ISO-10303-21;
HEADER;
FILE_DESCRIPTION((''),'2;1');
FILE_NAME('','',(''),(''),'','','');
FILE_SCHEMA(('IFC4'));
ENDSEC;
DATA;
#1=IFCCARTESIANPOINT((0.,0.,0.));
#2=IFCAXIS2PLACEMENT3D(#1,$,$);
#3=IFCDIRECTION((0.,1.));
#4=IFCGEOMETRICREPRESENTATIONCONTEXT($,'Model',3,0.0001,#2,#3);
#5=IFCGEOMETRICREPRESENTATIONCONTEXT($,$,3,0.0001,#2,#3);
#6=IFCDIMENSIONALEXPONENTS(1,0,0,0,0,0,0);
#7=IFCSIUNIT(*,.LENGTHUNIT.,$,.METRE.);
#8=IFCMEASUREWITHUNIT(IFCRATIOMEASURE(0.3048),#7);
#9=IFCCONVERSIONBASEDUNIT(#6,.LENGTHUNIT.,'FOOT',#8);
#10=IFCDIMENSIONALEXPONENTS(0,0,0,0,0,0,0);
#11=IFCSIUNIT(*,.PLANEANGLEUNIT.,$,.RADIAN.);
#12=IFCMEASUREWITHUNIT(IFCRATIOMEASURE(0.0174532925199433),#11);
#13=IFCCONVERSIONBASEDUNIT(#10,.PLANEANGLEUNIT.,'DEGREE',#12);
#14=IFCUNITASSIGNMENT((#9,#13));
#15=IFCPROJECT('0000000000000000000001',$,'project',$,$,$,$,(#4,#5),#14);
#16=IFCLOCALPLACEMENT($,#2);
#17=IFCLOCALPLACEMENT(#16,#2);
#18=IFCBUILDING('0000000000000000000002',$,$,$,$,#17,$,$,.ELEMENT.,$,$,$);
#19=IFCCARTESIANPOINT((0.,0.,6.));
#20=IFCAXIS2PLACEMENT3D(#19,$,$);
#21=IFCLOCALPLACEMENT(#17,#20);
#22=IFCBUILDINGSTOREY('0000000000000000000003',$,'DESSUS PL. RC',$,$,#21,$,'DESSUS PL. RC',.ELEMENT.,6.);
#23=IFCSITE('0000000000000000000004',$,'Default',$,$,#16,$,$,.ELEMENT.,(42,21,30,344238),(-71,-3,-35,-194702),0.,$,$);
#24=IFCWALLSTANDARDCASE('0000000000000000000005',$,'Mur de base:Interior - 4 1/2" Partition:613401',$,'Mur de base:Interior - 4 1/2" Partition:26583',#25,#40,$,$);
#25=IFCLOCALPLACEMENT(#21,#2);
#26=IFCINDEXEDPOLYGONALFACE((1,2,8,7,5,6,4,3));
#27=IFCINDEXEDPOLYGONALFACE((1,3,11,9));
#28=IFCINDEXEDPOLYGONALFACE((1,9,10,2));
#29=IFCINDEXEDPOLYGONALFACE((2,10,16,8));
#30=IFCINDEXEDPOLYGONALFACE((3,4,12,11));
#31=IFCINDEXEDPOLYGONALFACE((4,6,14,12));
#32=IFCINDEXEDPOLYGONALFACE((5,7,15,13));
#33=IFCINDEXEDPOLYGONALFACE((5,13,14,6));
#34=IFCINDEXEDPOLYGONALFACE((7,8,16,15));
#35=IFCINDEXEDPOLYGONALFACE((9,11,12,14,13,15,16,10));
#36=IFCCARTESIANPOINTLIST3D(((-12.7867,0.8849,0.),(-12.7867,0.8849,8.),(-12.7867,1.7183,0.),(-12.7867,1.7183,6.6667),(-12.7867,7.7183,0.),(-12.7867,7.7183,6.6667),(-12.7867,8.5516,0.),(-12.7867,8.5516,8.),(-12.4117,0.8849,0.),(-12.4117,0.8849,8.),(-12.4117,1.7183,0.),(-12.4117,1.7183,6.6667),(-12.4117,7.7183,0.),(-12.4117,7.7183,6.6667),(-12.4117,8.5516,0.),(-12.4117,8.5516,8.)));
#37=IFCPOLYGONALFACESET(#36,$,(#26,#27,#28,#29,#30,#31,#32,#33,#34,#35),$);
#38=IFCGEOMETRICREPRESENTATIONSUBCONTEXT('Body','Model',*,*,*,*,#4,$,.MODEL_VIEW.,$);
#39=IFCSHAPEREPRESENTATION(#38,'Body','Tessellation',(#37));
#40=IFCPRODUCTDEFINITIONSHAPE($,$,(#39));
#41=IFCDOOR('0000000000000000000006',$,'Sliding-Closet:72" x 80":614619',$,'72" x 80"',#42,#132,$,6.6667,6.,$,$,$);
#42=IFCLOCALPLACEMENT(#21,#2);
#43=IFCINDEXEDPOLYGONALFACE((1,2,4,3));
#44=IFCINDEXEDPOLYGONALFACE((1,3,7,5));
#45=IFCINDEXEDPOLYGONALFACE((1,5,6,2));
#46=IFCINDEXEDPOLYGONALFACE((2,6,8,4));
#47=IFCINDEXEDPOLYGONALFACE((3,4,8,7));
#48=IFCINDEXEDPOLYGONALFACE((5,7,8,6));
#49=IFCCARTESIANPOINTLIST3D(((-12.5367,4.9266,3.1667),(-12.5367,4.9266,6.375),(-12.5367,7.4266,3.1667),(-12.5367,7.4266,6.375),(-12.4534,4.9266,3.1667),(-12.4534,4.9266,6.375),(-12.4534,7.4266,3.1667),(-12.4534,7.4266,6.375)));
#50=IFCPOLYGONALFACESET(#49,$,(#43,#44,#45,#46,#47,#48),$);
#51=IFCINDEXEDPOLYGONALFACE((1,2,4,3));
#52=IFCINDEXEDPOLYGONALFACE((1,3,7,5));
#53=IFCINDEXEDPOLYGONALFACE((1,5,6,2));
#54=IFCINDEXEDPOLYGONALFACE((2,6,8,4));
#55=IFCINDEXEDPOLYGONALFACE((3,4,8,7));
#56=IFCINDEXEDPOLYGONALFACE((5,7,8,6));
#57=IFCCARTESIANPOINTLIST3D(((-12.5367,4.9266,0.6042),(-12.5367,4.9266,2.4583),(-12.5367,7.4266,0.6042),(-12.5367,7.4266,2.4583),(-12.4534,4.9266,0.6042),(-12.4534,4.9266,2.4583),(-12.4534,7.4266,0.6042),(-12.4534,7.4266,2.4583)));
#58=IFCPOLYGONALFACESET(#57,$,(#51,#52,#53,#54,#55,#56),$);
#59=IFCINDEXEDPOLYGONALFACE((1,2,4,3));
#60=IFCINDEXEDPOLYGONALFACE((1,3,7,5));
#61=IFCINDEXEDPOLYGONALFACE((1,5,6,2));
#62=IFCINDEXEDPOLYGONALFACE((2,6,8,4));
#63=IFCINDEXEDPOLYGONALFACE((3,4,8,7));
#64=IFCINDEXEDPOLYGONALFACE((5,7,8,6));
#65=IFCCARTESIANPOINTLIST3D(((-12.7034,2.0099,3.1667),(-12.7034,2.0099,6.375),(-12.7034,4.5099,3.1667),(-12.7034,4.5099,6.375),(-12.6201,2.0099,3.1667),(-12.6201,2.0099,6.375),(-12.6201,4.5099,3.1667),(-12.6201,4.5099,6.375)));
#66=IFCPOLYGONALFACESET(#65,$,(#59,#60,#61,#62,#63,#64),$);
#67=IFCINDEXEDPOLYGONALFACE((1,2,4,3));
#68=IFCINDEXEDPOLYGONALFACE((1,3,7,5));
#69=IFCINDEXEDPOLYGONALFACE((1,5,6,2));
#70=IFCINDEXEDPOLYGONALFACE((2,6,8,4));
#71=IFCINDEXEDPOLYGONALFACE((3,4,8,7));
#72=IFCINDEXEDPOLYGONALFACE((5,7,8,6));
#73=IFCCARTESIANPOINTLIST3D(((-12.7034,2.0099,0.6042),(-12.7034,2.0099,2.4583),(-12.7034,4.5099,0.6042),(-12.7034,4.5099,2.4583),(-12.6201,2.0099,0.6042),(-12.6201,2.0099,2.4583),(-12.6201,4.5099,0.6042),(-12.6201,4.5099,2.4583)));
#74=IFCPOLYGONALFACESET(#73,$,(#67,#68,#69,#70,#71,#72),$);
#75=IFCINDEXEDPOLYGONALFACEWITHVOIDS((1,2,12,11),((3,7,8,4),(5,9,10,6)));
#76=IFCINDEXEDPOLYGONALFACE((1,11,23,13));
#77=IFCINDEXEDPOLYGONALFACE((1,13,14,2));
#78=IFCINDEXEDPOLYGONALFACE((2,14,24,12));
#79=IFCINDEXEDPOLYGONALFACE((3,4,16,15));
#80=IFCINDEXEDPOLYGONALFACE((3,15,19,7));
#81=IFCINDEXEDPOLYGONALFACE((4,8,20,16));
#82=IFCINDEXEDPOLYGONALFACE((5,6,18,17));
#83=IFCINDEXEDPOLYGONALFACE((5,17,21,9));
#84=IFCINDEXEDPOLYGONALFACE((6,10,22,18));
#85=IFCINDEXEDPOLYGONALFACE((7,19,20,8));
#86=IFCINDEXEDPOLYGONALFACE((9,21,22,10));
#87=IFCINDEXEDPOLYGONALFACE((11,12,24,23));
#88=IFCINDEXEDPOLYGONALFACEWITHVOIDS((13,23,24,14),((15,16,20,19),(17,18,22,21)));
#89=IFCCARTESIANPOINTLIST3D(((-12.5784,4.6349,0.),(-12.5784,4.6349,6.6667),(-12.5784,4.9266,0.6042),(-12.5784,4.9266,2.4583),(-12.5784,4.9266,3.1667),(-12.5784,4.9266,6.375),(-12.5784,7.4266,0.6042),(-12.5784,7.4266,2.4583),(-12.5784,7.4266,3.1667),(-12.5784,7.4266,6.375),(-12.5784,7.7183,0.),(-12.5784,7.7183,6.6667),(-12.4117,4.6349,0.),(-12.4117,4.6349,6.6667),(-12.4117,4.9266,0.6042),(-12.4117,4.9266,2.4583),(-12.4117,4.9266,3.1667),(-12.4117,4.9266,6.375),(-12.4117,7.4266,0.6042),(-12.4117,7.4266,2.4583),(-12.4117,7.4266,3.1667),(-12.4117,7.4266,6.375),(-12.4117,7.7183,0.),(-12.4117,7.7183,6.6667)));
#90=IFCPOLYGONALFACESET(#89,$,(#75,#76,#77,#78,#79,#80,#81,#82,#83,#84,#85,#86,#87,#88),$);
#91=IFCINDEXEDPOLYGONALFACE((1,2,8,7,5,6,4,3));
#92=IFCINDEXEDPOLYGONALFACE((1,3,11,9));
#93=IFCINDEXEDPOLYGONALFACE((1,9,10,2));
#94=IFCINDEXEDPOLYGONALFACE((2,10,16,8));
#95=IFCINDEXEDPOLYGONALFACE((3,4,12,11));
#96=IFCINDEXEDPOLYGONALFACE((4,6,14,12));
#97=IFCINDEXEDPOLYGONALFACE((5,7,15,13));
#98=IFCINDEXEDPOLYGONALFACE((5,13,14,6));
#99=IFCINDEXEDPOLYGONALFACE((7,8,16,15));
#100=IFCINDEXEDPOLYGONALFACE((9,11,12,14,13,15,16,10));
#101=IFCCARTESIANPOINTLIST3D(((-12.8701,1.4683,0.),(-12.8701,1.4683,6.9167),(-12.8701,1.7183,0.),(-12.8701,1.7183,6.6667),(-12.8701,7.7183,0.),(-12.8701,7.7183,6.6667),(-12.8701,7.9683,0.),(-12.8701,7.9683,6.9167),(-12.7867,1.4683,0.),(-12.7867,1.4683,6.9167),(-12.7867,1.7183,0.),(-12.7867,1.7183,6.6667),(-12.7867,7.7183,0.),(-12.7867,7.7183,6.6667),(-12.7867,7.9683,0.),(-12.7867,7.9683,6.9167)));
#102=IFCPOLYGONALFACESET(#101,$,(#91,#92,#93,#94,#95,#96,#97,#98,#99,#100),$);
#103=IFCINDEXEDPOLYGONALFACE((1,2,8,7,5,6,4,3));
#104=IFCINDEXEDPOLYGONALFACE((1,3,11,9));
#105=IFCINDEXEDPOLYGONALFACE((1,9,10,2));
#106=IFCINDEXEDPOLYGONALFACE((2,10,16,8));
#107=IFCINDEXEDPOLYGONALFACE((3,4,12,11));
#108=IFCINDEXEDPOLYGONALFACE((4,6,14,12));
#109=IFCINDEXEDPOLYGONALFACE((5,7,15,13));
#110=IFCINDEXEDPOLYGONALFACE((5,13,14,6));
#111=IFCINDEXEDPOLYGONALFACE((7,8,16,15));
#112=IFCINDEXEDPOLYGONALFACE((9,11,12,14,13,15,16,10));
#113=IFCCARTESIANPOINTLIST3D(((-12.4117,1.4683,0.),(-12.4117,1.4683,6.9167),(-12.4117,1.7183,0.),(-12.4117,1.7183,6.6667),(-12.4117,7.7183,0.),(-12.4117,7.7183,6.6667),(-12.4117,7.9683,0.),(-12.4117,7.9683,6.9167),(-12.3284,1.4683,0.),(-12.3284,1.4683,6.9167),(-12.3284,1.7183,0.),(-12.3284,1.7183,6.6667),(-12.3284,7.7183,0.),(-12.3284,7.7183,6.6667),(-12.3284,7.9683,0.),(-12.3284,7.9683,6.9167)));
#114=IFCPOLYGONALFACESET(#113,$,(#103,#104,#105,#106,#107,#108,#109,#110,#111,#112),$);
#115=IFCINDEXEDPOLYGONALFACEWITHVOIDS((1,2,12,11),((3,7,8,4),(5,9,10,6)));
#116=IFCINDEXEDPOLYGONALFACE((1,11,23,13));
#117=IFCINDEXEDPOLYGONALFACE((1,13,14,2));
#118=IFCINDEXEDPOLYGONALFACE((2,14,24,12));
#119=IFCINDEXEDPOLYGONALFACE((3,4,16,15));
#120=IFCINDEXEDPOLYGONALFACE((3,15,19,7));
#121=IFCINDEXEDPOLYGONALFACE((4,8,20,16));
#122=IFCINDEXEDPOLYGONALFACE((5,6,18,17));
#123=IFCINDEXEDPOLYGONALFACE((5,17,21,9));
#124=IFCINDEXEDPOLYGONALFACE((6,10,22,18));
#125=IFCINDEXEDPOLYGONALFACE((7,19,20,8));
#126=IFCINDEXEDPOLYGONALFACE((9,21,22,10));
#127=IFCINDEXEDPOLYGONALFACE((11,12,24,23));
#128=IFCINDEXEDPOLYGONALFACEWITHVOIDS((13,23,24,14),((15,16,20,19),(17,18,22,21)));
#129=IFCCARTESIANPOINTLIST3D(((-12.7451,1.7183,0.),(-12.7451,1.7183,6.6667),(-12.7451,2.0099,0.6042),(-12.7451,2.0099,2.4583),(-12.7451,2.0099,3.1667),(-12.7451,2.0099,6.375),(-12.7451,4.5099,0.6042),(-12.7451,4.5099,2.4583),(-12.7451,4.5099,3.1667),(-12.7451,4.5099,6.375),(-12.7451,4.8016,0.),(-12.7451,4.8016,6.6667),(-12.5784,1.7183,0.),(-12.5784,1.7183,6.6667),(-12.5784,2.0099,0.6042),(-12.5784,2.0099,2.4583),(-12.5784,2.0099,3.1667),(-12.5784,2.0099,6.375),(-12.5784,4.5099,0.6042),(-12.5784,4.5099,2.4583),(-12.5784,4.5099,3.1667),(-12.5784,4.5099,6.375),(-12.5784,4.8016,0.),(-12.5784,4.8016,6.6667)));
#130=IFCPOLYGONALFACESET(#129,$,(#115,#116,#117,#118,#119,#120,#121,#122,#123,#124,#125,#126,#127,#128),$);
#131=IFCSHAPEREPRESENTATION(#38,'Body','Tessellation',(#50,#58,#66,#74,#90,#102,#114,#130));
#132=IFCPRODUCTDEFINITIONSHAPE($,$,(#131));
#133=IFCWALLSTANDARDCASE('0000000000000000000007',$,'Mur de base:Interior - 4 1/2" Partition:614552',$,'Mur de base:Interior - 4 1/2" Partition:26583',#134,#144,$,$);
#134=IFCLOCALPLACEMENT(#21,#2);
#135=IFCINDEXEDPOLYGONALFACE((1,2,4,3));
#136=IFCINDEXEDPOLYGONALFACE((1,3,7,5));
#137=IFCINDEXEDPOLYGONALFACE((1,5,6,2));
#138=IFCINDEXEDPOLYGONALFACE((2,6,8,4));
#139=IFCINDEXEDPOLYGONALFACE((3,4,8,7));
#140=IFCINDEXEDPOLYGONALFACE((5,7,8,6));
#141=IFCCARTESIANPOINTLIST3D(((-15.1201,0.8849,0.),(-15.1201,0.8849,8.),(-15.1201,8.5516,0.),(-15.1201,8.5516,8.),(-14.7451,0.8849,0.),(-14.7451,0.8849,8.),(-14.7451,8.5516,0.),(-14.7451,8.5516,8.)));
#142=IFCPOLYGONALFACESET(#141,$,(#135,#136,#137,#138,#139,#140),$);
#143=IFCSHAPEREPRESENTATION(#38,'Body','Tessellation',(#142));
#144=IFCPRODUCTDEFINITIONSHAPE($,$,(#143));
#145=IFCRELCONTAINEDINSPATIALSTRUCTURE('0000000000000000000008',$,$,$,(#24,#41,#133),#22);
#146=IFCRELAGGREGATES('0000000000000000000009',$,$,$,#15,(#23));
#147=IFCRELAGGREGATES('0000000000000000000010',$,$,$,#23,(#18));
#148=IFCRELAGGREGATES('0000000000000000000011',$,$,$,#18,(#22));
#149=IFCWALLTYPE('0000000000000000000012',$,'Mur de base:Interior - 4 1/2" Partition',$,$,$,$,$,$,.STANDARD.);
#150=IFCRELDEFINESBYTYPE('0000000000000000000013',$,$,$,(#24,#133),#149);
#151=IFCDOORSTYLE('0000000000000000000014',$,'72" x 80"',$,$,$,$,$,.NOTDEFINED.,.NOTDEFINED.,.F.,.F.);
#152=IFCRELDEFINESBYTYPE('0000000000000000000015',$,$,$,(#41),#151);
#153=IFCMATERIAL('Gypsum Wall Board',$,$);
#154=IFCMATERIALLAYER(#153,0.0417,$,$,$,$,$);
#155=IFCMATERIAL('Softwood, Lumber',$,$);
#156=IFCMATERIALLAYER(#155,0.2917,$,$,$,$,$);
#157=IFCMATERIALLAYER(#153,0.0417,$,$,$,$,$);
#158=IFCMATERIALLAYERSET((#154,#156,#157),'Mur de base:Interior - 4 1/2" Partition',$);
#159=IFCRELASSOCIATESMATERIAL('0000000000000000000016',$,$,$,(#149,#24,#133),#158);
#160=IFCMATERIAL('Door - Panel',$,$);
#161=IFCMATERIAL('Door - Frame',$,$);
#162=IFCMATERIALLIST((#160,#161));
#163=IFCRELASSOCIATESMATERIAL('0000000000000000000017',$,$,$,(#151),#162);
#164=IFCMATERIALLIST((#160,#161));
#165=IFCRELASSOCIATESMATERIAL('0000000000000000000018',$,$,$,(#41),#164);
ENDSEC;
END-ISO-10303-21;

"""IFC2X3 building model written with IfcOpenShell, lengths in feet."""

from ifc_helpers import new_model, entity, si_unit, converted_unit, direction, frame, frame_2d, origin, origin_2d_with_axis, place, context, subcontext, project, spatial, polyline, rectangle, outline, extrude, source, transform, mapped, material, material_list, layer, layer_set, layer_usage, type_object, type_shapes, element, fill, save


model = new_model("IFC2X3")

# Units and contexts
model_context = context("Model", 3, precision=0.0001, world=origin(), true_north=direction((0.0, 1.0)))
context_of_model = context(None, 3, precision=0.0001, world=origin(), true_north=direction((0.0, 1.0)))
body_context = subcontext(model_context, "Body", "Model", "MODEL_VIEW")
ifc_project = project(units=[converted_unit("LENGTHUNIT", "FOOT", entity("IfcRatioMeasure", 0.3048), si_unit("LENGTHUNIT", "METRE"), dimensions=[1, 0, 0, 0, 0, 0, 0]), converted_unit("PLANEANGLEUNIT", "DEGREE", entity("IfcRatioMeasure", 0.0174532925199433), si_unit("PLANEANGLEUNIT", "RADIAN"), dimensions=[0, 0, 0, 0, 0, 0, 0])], contexts=[model_context, context_of_model])

# Site, building, storey
site_placement = place(None, origin())
site = spatial("IfcSite", under=ifc_project, at=site_placement, Name="Default", CompositionType="ELEMENT", RefLatitude=(42, 21, 30, 344238), RefLongitude=(-71, -3, -35, -194702), RefElevation=0.0)
building_placement = place(site_placement, origin())
building = spatial("IfcBuilding", under=site, at=building_placement, CompositionType="ELEMENT")
storey_placement = place(building_placement, frame((0.0, 0.0, 6.0)))
storey = spatial("IfcBuildingStorey", under=building, at=storey_placement, Name="DESSUS PL. RC", LongName="DESSUS PL. RC", CompositionType="ELEMENT", Elevation=6.0)

# Shared definitions
ifc_material_1 = material(Name="Softwood, Lumber")
ifc_material_2 = material(Name="Gypsum Wall Board")

# Shared definitions
ifc_layer_1 = layer(ifc_material_2, 0.0417)
ifc_layer_2 = layer(ifc_material_1, 0.2917)
ifc_layer_3 = layer(ifc_material_2, 0.0417)
ifc_layer_set_1 = layer_set([ifc_layer_1, ifc_layer_2, ifc_layer_3], Name="Mur de base:Interior - 4 1/2\" Partition")
wall_type_1 = type_object("IfcWallType", Name="Mur de base:Interior - 4 1/2\" Partition", PredefinedType="STANDARD", material=ifc_layer_set_1)
ifc_material_3 = material(Name="Door - Frame")
ifc_material_4 = material(Name="Door - Panel")

# Wall, opening, door
ifc_layer_usage_1 = layer_usage(ifc_layer_set_1, "AXIS2", "NEGATIVE", 0.1875)
wall_1_placement = place(storey_placement, frame((-12.5992, 8.5516, 0.0), z_axis=(0.0, 0.0, 1.0), x_axis=(0.0, -1.0, 0.0)))
wall_1 = element("IfcWallStandardCase", 1, at=wall_1_placement, inside=storey, type_object=wall_type_1, material=ifc_layer_usage_1, Name="Mur de base:Interior - 4 1/2\" Partition:613401", ObjectType="Mur de base:Interior - 4 1/2\" Partition:26583", context=body_context, shape_type="SweptSolid", body=[
    extrude(rectangle(XDim=7.6667, YDim=0.375, at=frame_2d((3.8333, 0.0), x_axis=(-1.0, 0.0))), origin(), (0.0, 0.0, 1.0), 8.0),
])
opening_1_placement = place(wall_1_placement, frame((0.8333, -0.1875, 0.0)))
opening_1 = element("IfcOpeningElement", 2, at=opening_1_placement, cuts=wall_1, ObjectType="Opening", context=body_context, shape_type="SweptSolid", body=[
    extrude(rectangle(XDim=6.6667, YDim=6.0, at=frame_2d((3.3333, 3.0), x_axis=(-1.0, 0.0))), frame((0.0, 0.0, 0.0), z_axis=(0.0, 1.0, 0.0), x_axis=(0.0, 0.0, 1.0)), (0.0, 0.0, 1.0), 0.375),
])
ifc_material_list_1 = material_list([ifc_material_4, ifc_material_3])
ifc_material_list_2 = material_list([ifc_material_4, ifc_material_3])
door_style_1 = type_object("IfcDoorStyle", Name="72\" x 80\"", ConstructionType="NOTDEFINED", OperationType="NOTDEFINED", ParameterTakesPrecedence=False, Sizeable=False, material=ifc_material_list_2)
shared_shape_1 = source(origin(), body_context, "Body", "SweptSolid", [
    extrude(rectangle(XDim=0.0833, YDim=2.5, at=origin_2d_with_axis()), frame((1.5417, 0.2917, 3.1667), z_axis=(0.0, 0.0, 1.0), x_axis=(0.0, 1.0, 0.0)), (0.0, 0.0, 1.0), 3.2083),
    extrude(rectangle(XDim=0.0833, YDim=2.5, at=origin_2d_with_axis()), frame((1.5417, 0.2917, 0.6042), z_axis=(0.0, 0.0, 1.0), x_axis=(0.0, 1.0, 0.0)), (0.0, 0.0, 1.0), 1.8542),
    extrude(rectangle(XDim=0.0833, YDim=2.5, at=origin_2d_with_axis()), frame((4.4583, 0.125, 3.1667), z_axis=(0.0, 0.0, 1.0), x_axis=(0.0, -1.0, 0.0)), (0.0, 0.0, 1.0), 3.2083),
    extrude(rectangle(XDim=0.0833, YDim=2.5, at=origin_2d_with_axis()), frame((4.4583, 0.125, 0.6042), z_axis=(0.0, 0.0, 1.0), x_axis=(0.0, -1.0, 0.0)), (0.0, 0.0, 1.0), 1.8542),
    extrude(outline(polyline([(-3.3333, -1.5417), (3.3333, -1.5417), (3.3333, 1.5417), (-3.3333, 1.5417), (-3.3333, -1.5417)]), holes=[polyline([(2.7292, 1.25), (2.7292, -1.25), (0.875, -1.25), (0.875, 1.25), (2.7292, 1.25)]), polyline([(0.1667, 1.25), (0.1667, -1.25), (-3.0417, -1.25), (-3.0417, 1.25), (0.1667, 1.25)])]), frame((1.5417, 0.2083, 3.3333), z_axis=(0.0, 1.0, 0.0), x_axis=(0.0, 0.0, -1.0)), (0.0, 0.0, 1.0), 0.1667),
    extrude(outline(polyline([(-3.3958, -3.25), (3.5208, -3.25), (3.5208, 3.25), (-3.3958, 3.25), (-3.3958, 3.0), (3.2708, 3.0), (3.2708, -3.0), (-3.3958, -3.0), (-3.3958, -3.25)])), frame((3.0, -0.0833, 3.3958), z_axis=(0.0, 1.0, 0.0), x_axis=(0.0, 0.0, 1.0)), (0.0, 0.0, 1.0), 0.0833),
    extrude(outline(polyline([(-3.25, -3.3958), (-3.0, -3.3958), (-3.0, 3.2708), (3.0, 3.2708), (3.0, -3.3958), (3.25, -3.3958), (3.25, 3.5208), (-3.25, 3.5208), (-3.25, -3.3958)])), frame((3.0, 0.375, 3.3958), z_axis=(0.0, 1.0, 0.0), x_axis=(-1.0, 0.0, 0.0)), (0.0, 0.0, 1.0), 0.0833),
    extrude(outline(polyline([(-1.5417, -3.3333), (1.5417, -3.3333), (1.5417, 3.3333), (-1.5417, 3.3333), (-1.5417, -3.3333)]), holes=[polyline([(1.25, 0.1667), (1.25, -3.0417), (-1.25, -3.0417), (-1.25, 0.1667), (1.25, 0.1667)]), polyline([(1.25, 2.7292), (1.25, 0.875), (-1.25, 0.875), (-1.25, 2.7292), (1.25, 2.7292)])]), frame((4.4583, 0.0417, 3.3333), z_axis=(0.0, 1.0, 0.0), x_axis=(1.0, 0.0, 0.0)), (0.0, 0.0, 1.0), 0.1667),
])
type_shapes(door_style_1, [shared_shape_1])
door_1_placement = place(opening_1_placement, origin())
door_1 = element("IfcDoor", 3, at=door_1_placement, inside=storey, type_object=door_style_1, material=ifc_material_list_1, Name="Sliding-Closet:72\" x 80\":614619", ObjectType="72\" x 80\"", OverallHeight=6.6667, OverallWidth=6.0, context=body_context, shape_type="MappedRepresentation", body=[
    mapped(shared_shape_1, transform((0.0, 0.0, 0.0), scale=1.0)),
])
fill(opening_1, door_1)

# Wall
ifc_layer_usage_2 = layer_usage(ifc_layer_set_1, "AXIS2", "NEGATIVE", 0.1875)
wall_2_placement = place(storey_placement, frame((-14.9326, 8.5516, 0.0), z_axis=(0.0, 0.0, 1.0), x_axis=(0.0, -1.0, 0.0)))
element("IfcWallStandardCase", 4, at=wall_2_placement, inside=storey, type_object=wall_type_1, material=ifc_layer_usage_2, Name="Mur de base:Interior - 4 1/2\" Partition:614552", ObjectType="Mur de base:Interior - 4 1/2\" Partition:26583", context=body_context, shape_type="SweptSolid", body=[
    extrude(rectangle(XDim=7.6667, YDim=0.375, at=frame_2d((3.8333, 0.0), x_axis=(-1.0, 0.0))), origin(), (0.0, 0.0, 1.0), 8.0),
])

save(model, "model.ifc")
